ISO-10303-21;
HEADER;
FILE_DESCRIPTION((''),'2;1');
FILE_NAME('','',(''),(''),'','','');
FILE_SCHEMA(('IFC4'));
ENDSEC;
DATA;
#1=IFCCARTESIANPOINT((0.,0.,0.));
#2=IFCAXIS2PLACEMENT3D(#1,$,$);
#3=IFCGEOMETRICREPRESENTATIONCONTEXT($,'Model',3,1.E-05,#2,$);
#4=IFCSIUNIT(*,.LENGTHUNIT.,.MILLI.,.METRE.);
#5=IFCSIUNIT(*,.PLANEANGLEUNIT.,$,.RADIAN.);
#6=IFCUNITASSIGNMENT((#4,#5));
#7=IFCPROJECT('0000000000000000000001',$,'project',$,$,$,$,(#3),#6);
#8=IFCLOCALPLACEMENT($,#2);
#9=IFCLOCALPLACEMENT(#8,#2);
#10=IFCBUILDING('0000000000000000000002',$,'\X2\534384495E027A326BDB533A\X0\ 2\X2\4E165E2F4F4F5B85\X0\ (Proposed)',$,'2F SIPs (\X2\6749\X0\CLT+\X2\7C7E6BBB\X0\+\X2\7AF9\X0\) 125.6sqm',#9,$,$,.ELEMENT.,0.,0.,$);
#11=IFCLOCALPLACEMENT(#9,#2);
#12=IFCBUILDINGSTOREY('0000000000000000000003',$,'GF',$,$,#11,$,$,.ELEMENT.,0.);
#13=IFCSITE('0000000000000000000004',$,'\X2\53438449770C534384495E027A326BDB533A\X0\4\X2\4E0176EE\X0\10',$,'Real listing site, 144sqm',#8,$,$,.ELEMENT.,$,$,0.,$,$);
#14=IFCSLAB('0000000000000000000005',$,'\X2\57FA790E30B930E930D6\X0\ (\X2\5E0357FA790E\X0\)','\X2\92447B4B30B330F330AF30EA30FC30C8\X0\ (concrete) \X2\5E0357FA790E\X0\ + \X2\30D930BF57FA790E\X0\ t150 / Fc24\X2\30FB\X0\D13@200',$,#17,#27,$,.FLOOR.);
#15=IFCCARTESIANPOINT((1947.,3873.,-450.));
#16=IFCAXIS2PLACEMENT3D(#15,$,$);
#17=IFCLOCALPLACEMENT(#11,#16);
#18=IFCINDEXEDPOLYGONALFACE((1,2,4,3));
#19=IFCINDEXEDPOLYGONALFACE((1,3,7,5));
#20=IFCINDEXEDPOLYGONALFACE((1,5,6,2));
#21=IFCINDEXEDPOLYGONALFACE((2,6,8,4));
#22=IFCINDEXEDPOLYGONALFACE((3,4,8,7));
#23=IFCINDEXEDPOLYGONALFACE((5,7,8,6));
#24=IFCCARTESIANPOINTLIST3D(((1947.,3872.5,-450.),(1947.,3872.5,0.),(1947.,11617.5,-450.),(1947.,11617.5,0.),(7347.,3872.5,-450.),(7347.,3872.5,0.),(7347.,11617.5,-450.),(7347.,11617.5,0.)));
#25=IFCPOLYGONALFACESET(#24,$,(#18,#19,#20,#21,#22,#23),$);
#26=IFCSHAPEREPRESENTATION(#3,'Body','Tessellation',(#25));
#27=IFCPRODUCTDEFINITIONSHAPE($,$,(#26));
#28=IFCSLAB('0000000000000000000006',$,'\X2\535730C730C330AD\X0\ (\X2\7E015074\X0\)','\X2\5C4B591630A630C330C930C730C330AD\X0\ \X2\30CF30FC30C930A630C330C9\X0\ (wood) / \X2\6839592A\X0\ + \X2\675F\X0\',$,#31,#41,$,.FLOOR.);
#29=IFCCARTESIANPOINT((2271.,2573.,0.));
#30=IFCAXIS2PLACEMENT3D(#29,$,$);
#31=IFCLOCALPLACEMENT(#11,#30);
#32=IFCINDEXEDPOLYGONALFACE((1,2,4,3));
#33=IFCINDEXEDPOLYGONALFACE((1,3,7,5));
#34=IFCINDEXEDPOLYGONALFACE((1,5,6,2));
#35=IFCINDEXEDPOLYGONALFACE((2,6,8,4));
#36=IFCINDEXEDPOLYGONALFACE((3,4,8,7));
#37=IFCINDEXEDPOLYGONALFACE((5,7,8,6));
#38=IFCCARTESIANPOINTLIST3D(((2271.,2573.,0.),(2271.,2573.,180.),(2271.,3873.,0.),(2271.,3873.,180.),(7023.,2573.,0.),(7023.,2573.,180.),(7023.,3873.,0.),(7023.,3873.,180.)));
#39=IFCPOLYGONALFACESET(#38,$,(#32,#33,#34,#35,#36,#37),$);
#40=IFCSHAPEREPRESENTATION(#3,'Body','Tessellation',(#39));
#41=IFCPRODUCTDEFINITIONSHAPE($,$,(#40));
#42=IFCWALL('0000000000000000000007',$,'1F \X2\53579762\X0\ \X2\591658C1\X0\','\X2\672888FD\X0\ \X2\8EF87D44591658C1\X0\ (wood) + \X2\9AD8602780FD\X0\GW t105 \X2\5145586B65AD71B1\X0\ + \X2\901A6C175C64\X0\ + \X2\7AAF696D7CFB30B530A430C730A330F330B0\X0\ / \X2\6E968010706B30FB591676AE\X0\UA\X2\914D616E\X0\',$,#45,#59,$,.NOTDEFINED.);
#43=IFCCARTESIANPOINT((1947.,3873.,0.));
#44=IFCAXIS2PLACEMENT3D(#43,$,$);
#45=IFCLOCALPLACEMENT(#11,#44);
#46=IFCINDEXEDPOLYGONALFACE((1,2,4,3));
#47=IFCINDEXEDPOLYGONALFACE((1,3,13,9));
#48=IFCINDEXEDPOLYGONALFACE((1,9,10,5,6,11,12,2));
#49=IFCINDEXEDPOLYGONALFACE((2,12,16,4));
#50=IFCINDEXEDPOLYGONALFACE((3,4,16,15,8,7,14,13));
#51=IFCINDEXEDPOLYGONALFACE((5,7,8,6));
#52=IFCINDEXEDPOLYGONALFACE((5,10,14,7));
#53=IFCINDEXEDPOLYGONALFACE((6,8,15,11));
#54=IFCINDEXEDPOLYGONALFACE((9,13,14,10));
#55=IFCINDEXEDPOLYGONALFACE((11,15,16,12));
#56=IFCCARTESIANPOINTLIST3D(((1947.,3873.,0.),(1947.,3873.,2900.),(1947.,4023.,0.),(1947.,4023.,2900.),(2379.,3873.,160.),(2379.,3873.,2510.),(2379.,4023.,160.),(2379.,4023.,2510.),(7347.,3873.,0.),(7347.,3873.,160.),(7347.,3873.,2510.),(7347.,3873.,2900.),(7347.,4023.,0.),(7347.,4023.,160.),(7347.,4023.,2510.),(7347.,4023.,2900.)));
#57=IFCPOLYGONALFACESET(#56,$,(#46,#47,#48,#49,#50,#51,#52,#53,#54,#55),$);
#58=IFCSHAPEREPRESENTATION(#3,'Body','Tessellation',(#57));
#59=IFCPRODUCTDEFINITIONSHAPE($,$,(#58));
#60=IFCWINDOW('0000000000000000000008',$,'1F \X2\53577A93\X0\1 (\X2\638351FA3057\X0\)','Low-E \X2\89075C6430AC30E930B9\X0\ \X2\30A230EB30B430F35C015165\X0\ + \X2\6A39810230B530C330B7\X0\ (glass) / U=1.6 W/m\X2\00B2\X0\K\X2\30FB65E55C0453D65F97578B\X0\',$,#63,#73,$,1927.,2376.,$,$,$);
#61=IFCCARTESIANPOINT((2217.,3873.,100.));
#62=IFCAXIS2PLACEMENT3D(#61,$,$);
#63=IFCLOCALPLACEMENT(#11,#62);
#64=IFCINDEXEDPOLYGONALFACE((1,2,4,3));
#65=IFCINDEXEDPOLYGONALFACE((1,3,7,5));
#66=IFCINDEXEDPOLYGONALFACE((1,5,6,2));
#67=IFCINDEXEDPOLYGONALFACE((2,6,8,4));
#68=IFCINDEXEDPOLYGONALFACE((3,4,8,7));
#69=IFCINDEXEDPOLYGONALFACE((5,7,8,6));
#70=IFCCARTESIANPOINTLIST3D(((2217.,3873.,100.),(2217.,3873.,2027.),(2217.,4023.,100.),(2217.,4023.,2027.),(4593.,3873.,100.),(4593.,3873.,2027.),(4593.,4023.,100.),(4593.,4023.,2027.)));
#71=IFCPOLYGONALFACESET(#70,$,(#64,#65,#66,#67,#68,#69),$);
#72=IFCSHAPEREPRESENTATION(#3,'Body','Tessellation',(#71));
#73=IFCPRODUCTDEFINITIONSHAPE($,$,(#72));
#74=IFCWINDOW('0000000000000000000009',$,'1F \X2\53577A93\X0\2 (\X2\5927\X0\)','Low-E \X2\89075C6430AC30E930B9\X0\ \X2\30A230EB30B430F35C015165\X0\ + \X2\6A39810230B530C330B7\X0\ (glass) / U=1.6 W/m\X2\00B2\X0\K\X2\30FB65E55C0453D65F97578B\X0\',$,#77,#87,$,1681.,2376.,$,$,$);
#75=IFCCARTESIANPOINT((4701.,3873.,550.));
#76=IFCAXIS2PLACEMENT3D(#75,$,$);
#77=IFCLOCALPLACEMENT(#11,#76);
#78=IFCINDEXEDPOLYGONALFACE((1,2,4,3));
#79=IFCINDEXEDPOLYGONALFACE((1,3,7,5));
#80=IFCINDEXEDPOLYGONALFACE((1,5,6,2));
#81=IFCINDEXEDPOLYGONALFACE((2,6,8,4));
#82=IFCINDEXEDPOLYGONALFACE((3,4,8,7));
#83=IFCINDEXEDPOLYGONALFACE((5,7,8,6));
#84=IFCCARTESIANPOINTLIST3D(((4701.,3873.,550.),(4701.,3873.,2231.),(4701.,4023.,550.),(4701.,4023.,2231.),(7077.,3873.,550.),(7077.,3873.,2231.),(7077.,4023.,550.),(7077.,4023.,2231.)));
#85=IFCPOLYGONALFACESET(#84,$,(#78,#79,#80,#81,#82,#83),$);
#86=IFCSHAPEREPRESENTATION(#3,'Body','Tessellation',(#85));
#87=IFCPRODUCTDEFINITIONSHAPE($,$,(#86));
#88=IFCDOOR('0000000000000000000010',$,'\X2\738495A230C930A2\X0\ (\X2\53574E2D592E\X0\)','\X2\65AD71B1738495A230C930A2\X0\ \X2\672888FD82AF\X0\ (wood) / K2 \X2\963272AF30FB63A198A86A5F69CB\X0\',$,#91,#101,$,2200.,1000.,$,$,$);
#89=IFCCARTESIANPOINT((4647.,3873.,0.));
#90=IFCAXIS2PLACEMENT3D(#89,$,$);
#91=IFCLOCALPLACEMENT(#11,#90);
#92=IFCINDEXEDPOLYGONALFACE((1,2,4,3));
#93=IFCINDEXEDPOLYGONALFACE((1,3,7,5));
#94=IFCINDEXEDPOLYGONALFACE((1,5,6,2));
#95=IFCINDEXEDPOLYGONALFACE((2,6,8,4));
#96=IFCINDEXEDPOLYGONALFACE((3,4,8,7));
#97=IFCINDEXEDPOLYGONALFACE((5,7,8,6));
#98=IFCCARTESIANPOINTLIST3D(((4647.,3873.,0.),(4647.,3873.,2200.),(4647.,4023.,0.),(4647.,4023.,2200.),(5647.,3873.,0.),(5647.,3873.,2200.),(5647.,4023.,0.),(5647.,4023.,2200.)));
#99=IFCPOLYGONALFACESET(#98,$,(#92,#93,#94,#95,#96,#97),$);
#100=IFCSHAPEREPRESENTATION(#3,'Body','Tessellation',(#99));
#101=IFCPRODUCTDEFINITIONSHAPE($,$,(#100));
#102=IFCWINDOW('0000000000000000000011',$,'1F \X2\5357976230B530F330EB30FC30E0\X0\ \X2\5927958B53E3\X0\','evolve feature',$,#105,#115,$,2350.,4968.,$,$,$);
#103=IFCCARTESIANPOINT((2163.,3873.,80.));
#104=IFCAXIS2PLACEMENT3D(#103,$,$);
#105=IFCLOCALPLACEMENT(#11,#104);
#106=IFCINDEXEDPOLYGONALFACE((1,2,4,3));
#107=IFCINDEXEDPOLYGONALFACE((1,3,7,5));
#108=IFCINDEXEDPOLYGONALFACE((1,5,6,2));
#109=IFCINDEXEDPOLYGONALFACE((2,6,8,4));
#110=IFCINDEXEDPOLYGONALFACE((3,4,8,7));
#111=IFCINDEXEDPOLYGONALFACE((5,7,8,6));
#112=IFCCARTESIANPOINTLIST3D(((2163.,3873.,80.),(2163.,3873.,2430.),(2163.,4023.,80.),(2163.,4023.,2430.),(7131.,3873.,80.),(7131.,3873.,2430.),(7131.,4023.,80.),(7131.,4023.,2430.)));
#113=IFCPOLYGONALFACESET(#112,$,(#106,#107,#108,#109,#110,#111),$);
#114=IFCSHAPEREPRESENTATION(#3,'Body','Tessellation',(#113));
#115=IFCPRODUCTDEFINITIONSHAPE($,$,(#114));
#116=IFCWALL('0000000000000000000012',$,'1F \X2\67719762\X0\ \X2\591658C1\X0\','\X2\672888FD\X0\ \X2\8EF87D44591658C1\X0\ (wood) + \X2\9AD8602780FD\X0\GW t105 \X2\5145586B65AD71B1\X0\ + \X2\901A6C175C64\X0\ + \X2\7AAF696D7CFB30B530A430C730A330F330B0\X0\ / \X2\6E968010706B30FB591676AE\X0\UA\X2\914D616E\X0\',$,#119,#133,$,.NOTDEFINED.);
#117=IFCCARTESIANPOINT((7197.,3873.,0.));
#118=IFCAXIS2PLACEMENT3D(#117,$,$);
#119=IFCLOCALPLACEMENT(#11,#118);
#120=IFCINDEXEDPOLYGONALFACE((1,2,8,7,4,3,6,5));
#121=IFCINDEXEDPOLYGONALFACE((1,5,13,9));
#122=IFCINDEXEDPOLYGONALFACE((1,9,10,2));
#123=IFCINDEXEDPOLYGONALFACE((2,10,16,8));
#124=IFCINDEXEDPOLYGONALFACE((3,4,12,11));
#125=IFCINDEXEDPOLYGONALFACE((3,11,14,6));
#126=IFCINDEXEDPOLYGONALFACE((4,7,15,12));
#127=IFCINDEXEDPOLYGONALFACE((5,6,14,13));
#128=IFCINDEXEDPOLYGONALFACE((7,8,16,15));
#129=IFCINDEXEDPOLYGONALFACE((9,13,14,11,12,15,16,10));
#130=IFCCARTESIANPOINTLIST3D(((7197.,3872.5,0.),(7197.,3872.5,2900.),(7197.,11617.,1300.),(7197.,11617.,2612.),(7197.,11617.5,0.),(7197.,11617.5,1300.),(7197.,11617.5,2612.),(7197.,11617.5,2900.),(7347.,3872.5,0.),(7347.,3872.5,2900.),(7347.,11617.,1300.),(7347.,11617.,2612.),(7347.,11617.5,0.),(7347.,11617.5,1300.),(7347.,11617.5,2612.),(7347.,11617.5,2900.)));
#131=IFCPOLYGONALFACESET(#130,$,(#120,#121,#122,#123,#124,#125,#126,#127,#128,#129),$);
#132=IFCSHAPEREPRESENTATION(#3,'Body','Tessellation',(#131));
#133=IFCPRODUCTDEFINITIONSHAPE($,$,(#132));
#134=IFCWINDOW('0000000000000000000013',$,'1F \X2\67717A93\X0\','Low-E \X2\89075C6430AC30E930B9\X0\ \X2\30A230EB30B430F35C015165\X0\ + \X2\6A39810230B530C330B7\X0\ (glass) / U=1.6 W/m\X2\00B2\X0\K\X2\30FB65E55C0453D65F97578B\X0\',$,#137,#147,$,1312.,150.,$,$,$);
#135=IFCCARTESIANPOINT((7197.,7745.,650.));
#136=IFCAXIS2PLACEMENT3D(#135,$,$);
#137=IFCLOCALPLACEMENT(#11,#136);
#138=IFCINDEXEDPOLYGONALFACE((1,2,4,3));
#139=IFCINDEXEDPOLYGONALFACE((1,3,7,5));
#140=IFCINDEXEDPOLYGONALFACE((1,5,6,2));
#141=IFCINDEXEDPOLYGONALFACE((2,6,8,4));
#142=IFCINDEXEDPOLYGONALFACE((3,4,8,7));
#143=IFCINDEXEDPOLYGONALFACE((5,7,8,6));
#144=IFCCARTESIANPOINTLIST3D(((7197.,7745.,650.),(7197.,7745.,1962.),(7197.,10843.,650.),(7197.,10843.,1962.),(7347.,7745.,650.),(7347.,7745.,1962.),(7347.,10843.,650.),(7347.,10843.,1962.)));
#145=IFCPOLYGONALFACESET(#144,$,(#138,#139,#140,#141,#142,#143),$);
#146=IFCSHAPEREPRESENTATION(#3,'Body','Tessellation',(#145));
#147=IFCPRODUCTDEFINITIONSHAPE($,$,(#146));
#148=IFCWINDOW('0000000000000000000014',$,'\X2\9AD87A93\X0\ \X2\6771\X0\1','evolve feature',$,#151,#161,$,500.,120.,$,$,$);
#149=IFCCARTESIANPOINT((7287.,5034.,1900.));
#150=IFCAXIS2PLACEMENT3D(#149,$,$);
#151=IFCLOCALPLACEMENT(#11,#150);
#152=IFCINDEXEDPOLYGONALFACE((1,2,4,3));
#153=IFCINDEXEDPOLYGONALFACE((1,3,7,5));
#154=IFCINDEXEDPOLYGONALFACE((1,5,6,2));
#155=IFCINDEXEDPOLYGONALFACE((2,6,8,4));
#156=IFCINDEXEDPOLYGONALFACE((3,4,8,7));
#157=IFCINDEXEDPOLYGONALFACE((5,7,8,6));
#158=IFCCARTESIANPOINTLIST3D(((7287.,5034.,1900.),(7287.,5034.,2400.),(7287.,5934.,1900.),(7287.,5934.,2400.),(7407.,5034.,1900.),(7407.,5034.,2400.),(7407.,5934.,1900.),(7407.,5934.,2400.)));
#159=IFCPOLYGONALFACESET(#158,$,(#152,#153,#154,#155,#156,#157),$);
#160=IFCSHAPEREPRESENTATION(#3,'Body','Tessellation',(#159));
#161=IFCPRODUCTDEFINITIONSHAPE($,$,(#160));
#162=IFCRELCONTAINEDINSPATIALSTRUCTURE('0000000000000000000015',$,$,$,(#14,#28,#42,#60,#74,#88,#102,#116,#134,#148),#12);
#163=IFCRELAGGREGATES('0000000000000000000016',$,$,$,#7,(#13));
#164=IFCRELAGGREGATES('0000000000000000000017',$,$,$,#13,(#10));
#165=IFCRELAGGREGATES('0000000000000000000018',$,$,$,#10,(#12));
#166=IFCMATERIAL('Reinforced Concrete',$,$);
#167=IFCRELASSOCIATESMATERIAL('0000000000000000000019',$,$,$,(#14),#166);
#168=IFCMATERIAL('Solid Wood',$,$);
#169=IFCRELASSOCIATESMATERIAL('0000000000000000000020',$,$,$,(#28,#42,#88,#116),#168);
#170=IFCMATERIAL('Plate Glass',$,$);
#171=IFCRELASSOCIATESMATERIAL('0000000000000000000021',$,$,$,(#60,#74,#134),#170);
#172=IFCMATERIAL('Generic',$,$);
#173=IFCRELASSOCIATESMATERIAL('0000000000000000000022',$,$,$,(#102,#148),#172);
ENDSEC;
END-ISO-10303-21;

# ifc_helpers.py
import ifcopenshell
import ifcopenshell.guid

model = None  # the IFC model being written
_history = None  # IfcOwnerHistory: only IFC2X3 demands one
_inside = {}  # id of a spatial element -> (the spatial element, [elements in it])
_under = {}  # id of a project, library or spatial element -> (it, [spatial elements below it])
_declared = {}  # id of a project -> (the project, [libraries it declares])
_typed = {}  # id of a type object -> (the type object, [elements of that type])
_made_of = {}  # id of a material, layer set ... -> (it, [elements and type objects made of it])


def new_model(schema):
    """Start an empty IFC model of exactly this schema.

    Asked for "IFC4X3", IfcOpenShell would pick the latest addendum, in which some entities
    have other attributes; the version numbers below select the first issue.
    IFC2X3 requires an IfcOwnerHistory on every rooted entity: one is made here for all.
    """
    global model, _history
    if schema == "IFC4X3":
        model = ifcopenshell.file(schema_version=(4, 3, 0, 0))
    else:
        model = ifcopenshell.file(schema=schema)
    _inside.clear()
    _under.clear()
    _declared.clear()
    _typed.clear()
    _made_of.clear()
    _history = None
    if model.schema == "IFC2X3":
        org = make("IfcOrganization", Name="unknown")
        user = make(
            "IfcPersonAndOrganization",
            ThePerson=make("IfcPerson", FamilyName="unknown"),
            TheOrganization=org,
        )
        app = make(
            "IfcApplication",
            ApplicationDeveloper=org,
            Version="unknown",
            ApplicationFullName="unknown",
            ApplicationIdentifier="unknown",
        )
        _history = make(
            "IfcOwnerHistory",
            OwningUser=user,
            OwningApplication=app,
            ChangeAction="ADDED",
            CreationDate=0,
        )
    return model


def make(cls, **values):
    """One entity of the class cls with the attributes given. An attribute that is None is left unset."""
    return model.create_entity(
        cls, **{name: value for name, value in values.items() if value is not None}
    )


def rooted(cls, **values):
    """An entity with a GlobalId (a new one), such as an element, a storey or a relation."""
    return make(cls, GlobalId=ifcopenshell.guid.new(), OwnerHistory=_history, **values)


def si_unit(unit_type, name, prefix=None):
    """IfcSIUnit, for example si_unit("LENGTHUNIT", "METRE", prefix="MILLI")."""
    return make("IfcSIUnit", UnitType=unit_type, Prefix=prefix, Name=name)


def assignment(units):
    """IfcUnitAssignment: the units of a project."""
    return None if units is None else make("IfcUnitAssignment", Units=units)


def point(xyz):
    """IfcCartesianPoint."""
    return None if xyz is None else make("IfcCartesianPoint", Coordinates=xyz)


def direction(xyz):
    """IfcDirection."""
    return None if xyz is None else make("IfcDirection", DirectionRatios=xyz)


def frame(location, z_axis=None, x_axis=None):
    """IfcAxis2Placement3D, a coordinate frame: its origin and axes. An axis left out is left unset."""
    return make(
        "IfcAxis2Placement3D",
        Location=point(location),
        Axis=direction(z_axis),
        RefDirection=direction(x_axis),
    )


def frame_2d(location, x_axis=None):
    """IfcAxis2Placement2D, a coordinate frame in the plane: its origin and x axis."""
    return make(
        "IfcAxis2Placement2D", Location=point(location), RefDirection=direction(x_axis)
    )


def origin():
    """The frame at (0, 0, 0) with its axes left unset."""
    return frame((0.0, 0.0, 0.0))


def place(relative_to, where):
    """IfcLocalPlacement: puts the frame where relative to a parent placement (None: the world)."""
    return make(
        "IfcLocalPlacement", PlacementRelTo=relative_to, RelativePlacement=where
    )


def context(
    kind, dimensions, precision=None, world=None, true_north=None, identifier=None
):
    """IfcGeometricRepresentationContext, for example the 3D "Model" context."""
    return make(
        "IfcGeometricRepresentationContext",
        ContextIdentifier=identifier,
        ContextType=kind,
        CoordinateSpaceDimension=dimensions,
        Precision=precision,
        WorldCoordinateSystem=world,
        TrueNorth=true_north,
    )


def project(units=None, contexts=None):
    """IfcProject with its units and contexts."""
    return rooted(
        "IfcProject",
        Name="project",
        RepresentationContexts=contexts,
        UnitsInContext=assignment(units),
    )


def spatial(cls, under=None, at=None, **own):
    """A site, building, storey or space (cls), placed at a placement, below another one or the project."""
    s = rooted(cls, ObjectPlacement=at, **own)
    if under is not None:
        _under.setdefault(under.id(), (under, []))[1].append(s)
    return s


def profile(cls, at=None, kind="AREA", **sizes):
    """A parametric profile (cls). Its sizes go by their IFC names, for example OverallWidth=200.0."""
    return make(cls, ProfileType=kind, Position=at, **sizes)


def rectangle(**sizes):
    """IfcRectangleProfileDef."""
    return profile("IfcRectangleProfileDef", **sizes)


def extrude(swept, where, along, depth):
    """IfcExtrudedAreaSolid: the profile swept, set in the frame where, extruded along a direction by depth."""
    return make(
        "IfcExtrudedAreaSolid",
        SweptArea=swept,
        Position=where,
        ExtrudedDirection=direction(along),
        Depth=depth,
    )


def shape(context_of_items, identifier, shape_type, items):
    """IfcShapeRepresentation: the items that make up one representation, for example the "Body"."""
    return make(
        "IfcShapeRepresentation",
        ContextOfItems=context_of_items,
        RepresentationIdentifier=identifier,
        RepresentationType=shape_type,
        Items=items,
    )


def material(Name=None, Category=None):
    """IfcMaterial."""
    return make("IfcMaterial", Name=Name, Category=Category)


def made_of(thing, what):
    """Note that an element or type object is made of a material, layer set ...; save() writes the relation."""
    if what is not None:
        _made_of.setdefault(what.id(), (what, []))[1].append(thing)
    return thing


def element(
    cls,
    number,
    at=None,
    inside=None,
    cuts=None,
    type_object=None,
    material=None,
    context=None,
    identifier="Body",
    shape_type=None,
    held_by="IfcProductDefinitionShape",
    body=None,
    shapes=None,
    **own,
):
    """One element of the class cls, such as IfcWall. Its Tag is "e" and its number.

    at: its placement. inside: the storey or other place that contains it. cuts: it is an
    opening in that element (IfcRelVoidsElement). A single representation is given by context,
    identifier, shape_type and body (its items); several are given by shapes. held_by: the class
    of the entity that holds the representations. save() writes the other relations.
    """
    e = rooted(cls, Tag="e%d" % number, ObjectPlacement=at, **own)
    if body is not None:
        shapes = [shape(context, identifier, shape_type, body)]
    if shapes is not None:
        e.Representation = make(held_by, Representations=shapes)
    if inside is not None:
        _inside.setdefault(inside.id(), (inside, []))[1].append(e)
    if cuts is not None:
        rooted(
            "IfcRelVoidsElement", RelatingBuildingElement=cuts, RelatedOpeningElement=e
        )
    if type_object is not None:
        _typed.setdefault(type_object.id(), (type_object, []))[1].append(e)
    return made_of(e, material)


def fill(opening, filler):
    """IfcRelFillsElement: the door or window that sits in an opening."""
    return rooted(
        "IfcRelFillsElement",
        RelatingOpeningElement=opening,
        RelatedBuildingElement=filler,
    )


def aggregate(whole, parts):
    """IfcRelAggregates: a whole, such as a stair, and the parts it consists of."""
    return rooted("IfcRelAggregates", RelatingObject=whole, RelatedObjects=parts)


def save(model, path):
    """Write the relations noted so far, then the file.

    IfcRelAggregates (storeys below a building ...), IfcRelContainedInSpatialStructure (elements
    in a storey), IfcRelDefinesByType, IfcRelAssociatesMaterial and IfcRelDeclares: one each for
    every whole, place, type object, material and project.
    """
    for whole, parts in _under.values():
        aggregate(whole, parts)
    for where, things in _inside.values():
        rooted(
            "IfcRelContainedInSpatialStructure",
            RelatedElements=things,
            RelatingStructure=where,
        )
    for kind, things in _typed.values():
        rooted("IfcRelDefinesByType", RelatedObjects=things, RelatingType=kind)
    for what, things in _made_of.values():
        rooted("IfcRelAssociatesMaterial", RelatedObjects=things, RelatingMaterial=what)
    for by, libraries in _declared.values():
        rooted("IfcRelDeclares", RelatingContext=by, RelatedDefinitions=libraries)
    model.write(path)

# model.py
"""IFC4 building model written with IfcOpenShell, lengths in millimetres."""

from ifc_helpers import new_model, si_unit, frame, frame_2d, origin, place, context, project, spatial, rectangle, extrude, material, element, fill, save


model = new_model("IFC4")

# Units and contexts
model_context = context("Model", 3, precision=1e-05, world=origin())
ifc_project = project(units=[si_unit("LENGTHUNIT", "METRE", prefix="MILLI"), si_unit("PLANEANGLEUNIT", "RADIAN")], contexts=[model_context])

# Site, building, storey
site_placement = place(None, origin())
site = spatial("IfcSite", under=ifc_project, at=site_placement, Name="千葉県千葉市稲毛区4丁目10", ObjectType="Real listing site, 144sqm", CompositionType="ELEMENT", RefElevation=0.0)
building_placement = place(site_placement, origin())
building = spatial("IfcBuilding", under=site, at=building_placement, Name="千葉市稲毛区 2世帯住宅 (Proposed)", ObjectType="2F SIPs (杉CLT+籾殻+竹) 125.6sqm", CompositionType="ELEMENT", ElevationOfRefHeight=0.0, ElevationOfTerrain=0.0)
storey_placement = place(building_placement, origin())
storey = spatial("IfcBuildingStorey", under=building, at=storey_placement, Name="GF", CompositionType="ELEMENT", Elevation=0.0)

# Slabs
ifc_material_1 = material(Name="Reinforced Concrete")
slab_1_placement = place(storey_placement, frame((1947.0, 3873.0, -450.0)))
element("IfcSlab", 1, at=slab_1_placement, inside=storey, material=ifc_material_1, Name="基礎スラブ (布基礎)", Description="鉄筋コンクリート (concrete) 布基礎 + ベタ基礎 t150 / Fc24・D13@200", PredefinedType="FLOOR", context=model_context, shape_type="SweptSolid", body=[
    extrude(rectangle(XDim=5400.0, YDim=7745.0, at=frame_2d((2700.0, 3872.0))), frame((1947.0, 3873.0, -450.0)), (0.0, 0.0, 1.0), 450.0),
])
ifc_material_2 = material(Name="Solid Wood")
slab_2_placement = place(storey_placement, frame((2271.0, 2573.0, 0.0)))
element("IfcSlab", 2, at=slab_2_placement, inside=storey, material=ifc_material_2, Name="南デッキ (縁側)", Description="屋外ウッドデッキ ハードウッド (wood) / 根太 + 束", PredefinedType="FLOOR", context=model_context, shape_type="SweptSolid", body=[
    extrude(rectangle(XDim=4752.0, YDim=1300.0, at=frame_2d((2376.0, 650.0))), frame((2271.0, 2573.0, 0.0)), (0.0, 0.0, 1.0), 180.0),
])

# Wall, openings, windows, door
wall_1_placement = place(storey_placement, frame((1947.0, 3873.0, 0.0)))
wall_1 = element("IfcWall", 3, at=wall_1_placement, inside=storey, material=ifc_material_2, Name="1F 南面 外壁", Description="木製 軸組外壁 (wood) + 高性能GW t105 充填断熱 + 通気層 + 窯業系サイディング / 準耐火・外皮UA配慮", PredefinedType="NOTDEFINED", context=model_context, shape_type="SweptSolid", body=[
    extrude(rectangle(XDim=5400.0, YDim=150.0, at=frame_2d((2700.0, 75.0))), frame((1947.0, 3873.0, 0.0)), (0.0, 0.0, 1.0), 2900.0),
])
opening_1_placement = place(storey_placement, frame((2217.0, 3873.0, 100.0)))
opening_1 = element("IfcOpeningElement", 4, at=opening_1_placement, cuts=wall_1, PredefinedType="NOTDEFINED", context=model_context, shape_type="SweptSolid", body=[
    extrude(rectangle(XDim=2376.0, YDim=150.0, at=frame_2d((1188.0, 75.0))), frame((2217.0, 3873.0, 100.0)), (0.0, 0.0, 1.0), 1927.0),
])
opening_2_placement = place(storey_placement, frame((4701.0, 3873.0, 550.0)))
opening_2 = element("IfcOpeningElement", 5, at=opening_2_placement, cuts=wall_1, PredefinedType="NOTDEFINED", context=model_context, shape_type="SweptSolid", body=[
    extrude(rectangle(XDim=2376.0, YDim=150.0, at=frame_2d((1188.0, 75.0))), frame((4701.0, 3873.0, 550.0)), (0.0, 0.0, 1.0), 1681.0),
])
opening_3_placement = place(storey_placement, frame((4647.0, 3873.0, 0.0)))
opening_3 = element("IfcOpeningElement", 6, at=opening_3_placement, cuts=wall_1, PredefinedType="NOTDEFINED", context=model_context, shape_type="SweptSolid", body=[
    extrude(rectangle(XDim=1000.0, YDim=150.0, at=frame_2d((500.0, 75.0))), frame((4647.0, 3873.0, 0.0)), (0.0, 0.0, 1.0), 2200.0),
])
opening_4_placement = place(storey_placement, frame((2163.0, 3873.0, 80.0)))
opening_4 = element("IfcOpeningElement", 7, at=opening_4_placement, cuts=wall_1, PredefinedType="NOTDEFINED", context=model_context, shape_type="SweptSolid", body=[
    extrude(rectangle(XDim=4968.0, YDim=150.0, at=frame_2d((2484.0, 75.0))), frame((2163.0, 3873.0, 80.0)), (0.0, 0.0, 1.0), 2350.0),
])
ifc_material_3 = material(Name="Plate Glass")
window_1_placement = place(storey_placement, frame((2217.0, 3873.0, 100.0)))
window_1 = element("IfcWindow", 8, at=window_1_placement, inside=storey, material=ifc_material_3, Name="1F 南窓1 (掃出し)", Description="Low-E 複層ガラス アルゴン封入 + 樹脂サッシ (glass) / U=1.6 W/m²K・日射取得型", OverallHeight=1927.0, OverallWidth=2376.0, context=model_context, shape_type="SweptSolid", body=[
    extrude(rectangle(XDim=2376.0, YDim=150.0, at=frame_2d((1188.0, 75.0))), frame((2217.0, 3873.0, 100.0)), (0.0, 0.0, 1.0), 1927.0),
])
fill(opening_1, window_1)
window_2_placement = place(storey_placement, frame((4701.0, 3873.0, 550.0)))
window_2 = element("IfcWindow", 9, at=window_2_placement, inside=storey, material=ifc_material_3, Name="1F 南窓2 (大)", Description="Low-E 複層ガラス アルゴン封入 + 樹脂サッシ (glass) / U=1.6 W/m²K・日射取得型", OverallHeight=1681.0, OverallWidth=2376.0, context=model_context, shape_type="SweptSolid", body=[
    extrude(rectangle(XDim=2376.0, YDim=150.0, at=frame_2d((1188.0, 75.0))), frame((4701.0, 3873.0, 550.0)), (0.0, 0.0, 1.0), 1681.0),
])
fill(opening_2, window_2)
door_placement = place(storey_placement, frame((4647.0, 3873.0, 0.0)))
door = element("IfcDoor", 10, at=door_placement, inside=storey, material=ifc_material_2, Name="玄関ドア (南中央)", Description="断熱玄関ドア 木製芯 (wood) / K2 防犯・採風機構", OverallHeight=2200.0, OverallWidth=1000.0, context=model_context, shape_type="SweptSolid", body=[
    extrude(rectangle(XDim=1000.0, YDim=150.0, at=frame_2d((500.0, 75.0))), frame((4647.0, 3873.0, 0.0)), (0.0, 0.0, 1.0), 2200.0),
])
fill(opening_3, door)
ifc_material_4 = material(Name="Generic")
window_3_placement = place(storey_placement, frame((2163.0, 3873.0, 80.0)))
window_3 = element("IfcWindow", 11, at=window_3_placement, inside=storey, material=ifc_material_4, Name="1F 南面サンルーム 大開口", Description="evolve feature", OverallHeight=2350.0, OverallWidth=4968.0, context=model_context, shape_type="SweptSolid", body=[
    extrude(rectangle(XDim=4968.0, YDim=150.0, at=frame_2d((2484.0, 75.0))), frame((2163.0, 3873.0, 80.0)), (0.0, 0.0, 1.0), 2350.0),
])
fill(opening_4, window_3)

# Wall, openings, windows
wall_2_placement = place(storey_placement, frame((7197.0, 3873.0, 0.0)))
wall_2 = element("IfcWall", 12, at=wall_2_placement, inside=storey, material=ifc_material_2, Name="1F 東面 外壁", Description="木製 軸組外壁 (wood) + 高性能GW t105 充填断熱 + 通気層 + 窯業系サイディング / 準耐火・外皮UA配慮", PredefinedType="NOTDEFINED", context=model_context, shape_type="SweptSolid", body=[
    extrude(rectangle(XDim=150.0, YDim=7745.0, at=frame_2d((75.0, 3872.0))), frame((7197.0, 3873.0, 0.0)), (0.0, 0.0, 1.0), 2900.0),
])
opening_5_placement = place(storey_placement, frame((7197.0, 7745.0, 650.0)))
opening_5 = element("IfcOpeningElement", 13, at=opening_5_placement, cuts=wall_2, PredefinedType="NOTDEFINED", context=model_context, shape_type="SweptSolid", body=[
    extrude(rectangle(XDim=150.0, YDim=3098.0, at=frame_2d((75.0, 1549.0))), frame((7197.0, 7745.0, 650.0)), (0.0, 0.0, 1.0), 1312.0),
])
opening_6_placement = place(storey_placement, frame((7287.0, 5034.0, 1900.0)))
opening_6 = element("IfcOpeningElement", 14, at=opening_6_placement, cuts=wall_2, PredefinedType="NOTDEFINED", context=model_context, shape_type="SweptSolid", body=[
    extrude(rectangle(XDim=120.0, YDim=900.0, at=frame_2d((60.0, 450.0))), frame((7287.0, 5034.0, 1900.0)), (0.0, 0.0, 1.0), 500.0),
])
window_4_placement = place(storey_placement, frame((7197.0, 7745.0, 650.0)))
window_4 = element("IfcWindow", 15, at=window_4_placement, inside=storey, material=ifc_material_3, Name="1F 東窓", Description="Low-E 複層ガラス アルゴン封入 + 樹脂サッシ (glass) / U=1.6 W/m²K・日射取得型", OverallHeight=1312.0, OverallWidth=150.0, context=model_context, shape_type="SweptSolid", body=[
    extrude(rectangle(XDim=150.0, YDim=3098.0, at=frame_2d((75.0, 1549.0))), frame((7197.0, 7745.0, 650.0)), (0.0, 0.0, 1.0), 1312.0),
])
fill(opening_5, window_4)
window_5_placement = place(storey_placement, frame((7287.0, 5034.0, 1900.0)))
window_5 = element("IfcWindow", 16, at=window_5_placement, inside=storey, material=ifc_material_4, Name="高窓 東1", Description="evolve feature", OverallHeight=500.0, OverallWidth=120.0, context=model_context, shape_type="SweptSolid", body=[
    extrude(rectangle(XDim=120.0, YDim=900.0, at=frame_2d((60.0, 450.0))), frame((7287.0, 5034.0, 1900.0)), (0.0, 0.0, 1.0), 500.0),
])
fill(opening_6, window_5)

save(model, "model.ifc")
